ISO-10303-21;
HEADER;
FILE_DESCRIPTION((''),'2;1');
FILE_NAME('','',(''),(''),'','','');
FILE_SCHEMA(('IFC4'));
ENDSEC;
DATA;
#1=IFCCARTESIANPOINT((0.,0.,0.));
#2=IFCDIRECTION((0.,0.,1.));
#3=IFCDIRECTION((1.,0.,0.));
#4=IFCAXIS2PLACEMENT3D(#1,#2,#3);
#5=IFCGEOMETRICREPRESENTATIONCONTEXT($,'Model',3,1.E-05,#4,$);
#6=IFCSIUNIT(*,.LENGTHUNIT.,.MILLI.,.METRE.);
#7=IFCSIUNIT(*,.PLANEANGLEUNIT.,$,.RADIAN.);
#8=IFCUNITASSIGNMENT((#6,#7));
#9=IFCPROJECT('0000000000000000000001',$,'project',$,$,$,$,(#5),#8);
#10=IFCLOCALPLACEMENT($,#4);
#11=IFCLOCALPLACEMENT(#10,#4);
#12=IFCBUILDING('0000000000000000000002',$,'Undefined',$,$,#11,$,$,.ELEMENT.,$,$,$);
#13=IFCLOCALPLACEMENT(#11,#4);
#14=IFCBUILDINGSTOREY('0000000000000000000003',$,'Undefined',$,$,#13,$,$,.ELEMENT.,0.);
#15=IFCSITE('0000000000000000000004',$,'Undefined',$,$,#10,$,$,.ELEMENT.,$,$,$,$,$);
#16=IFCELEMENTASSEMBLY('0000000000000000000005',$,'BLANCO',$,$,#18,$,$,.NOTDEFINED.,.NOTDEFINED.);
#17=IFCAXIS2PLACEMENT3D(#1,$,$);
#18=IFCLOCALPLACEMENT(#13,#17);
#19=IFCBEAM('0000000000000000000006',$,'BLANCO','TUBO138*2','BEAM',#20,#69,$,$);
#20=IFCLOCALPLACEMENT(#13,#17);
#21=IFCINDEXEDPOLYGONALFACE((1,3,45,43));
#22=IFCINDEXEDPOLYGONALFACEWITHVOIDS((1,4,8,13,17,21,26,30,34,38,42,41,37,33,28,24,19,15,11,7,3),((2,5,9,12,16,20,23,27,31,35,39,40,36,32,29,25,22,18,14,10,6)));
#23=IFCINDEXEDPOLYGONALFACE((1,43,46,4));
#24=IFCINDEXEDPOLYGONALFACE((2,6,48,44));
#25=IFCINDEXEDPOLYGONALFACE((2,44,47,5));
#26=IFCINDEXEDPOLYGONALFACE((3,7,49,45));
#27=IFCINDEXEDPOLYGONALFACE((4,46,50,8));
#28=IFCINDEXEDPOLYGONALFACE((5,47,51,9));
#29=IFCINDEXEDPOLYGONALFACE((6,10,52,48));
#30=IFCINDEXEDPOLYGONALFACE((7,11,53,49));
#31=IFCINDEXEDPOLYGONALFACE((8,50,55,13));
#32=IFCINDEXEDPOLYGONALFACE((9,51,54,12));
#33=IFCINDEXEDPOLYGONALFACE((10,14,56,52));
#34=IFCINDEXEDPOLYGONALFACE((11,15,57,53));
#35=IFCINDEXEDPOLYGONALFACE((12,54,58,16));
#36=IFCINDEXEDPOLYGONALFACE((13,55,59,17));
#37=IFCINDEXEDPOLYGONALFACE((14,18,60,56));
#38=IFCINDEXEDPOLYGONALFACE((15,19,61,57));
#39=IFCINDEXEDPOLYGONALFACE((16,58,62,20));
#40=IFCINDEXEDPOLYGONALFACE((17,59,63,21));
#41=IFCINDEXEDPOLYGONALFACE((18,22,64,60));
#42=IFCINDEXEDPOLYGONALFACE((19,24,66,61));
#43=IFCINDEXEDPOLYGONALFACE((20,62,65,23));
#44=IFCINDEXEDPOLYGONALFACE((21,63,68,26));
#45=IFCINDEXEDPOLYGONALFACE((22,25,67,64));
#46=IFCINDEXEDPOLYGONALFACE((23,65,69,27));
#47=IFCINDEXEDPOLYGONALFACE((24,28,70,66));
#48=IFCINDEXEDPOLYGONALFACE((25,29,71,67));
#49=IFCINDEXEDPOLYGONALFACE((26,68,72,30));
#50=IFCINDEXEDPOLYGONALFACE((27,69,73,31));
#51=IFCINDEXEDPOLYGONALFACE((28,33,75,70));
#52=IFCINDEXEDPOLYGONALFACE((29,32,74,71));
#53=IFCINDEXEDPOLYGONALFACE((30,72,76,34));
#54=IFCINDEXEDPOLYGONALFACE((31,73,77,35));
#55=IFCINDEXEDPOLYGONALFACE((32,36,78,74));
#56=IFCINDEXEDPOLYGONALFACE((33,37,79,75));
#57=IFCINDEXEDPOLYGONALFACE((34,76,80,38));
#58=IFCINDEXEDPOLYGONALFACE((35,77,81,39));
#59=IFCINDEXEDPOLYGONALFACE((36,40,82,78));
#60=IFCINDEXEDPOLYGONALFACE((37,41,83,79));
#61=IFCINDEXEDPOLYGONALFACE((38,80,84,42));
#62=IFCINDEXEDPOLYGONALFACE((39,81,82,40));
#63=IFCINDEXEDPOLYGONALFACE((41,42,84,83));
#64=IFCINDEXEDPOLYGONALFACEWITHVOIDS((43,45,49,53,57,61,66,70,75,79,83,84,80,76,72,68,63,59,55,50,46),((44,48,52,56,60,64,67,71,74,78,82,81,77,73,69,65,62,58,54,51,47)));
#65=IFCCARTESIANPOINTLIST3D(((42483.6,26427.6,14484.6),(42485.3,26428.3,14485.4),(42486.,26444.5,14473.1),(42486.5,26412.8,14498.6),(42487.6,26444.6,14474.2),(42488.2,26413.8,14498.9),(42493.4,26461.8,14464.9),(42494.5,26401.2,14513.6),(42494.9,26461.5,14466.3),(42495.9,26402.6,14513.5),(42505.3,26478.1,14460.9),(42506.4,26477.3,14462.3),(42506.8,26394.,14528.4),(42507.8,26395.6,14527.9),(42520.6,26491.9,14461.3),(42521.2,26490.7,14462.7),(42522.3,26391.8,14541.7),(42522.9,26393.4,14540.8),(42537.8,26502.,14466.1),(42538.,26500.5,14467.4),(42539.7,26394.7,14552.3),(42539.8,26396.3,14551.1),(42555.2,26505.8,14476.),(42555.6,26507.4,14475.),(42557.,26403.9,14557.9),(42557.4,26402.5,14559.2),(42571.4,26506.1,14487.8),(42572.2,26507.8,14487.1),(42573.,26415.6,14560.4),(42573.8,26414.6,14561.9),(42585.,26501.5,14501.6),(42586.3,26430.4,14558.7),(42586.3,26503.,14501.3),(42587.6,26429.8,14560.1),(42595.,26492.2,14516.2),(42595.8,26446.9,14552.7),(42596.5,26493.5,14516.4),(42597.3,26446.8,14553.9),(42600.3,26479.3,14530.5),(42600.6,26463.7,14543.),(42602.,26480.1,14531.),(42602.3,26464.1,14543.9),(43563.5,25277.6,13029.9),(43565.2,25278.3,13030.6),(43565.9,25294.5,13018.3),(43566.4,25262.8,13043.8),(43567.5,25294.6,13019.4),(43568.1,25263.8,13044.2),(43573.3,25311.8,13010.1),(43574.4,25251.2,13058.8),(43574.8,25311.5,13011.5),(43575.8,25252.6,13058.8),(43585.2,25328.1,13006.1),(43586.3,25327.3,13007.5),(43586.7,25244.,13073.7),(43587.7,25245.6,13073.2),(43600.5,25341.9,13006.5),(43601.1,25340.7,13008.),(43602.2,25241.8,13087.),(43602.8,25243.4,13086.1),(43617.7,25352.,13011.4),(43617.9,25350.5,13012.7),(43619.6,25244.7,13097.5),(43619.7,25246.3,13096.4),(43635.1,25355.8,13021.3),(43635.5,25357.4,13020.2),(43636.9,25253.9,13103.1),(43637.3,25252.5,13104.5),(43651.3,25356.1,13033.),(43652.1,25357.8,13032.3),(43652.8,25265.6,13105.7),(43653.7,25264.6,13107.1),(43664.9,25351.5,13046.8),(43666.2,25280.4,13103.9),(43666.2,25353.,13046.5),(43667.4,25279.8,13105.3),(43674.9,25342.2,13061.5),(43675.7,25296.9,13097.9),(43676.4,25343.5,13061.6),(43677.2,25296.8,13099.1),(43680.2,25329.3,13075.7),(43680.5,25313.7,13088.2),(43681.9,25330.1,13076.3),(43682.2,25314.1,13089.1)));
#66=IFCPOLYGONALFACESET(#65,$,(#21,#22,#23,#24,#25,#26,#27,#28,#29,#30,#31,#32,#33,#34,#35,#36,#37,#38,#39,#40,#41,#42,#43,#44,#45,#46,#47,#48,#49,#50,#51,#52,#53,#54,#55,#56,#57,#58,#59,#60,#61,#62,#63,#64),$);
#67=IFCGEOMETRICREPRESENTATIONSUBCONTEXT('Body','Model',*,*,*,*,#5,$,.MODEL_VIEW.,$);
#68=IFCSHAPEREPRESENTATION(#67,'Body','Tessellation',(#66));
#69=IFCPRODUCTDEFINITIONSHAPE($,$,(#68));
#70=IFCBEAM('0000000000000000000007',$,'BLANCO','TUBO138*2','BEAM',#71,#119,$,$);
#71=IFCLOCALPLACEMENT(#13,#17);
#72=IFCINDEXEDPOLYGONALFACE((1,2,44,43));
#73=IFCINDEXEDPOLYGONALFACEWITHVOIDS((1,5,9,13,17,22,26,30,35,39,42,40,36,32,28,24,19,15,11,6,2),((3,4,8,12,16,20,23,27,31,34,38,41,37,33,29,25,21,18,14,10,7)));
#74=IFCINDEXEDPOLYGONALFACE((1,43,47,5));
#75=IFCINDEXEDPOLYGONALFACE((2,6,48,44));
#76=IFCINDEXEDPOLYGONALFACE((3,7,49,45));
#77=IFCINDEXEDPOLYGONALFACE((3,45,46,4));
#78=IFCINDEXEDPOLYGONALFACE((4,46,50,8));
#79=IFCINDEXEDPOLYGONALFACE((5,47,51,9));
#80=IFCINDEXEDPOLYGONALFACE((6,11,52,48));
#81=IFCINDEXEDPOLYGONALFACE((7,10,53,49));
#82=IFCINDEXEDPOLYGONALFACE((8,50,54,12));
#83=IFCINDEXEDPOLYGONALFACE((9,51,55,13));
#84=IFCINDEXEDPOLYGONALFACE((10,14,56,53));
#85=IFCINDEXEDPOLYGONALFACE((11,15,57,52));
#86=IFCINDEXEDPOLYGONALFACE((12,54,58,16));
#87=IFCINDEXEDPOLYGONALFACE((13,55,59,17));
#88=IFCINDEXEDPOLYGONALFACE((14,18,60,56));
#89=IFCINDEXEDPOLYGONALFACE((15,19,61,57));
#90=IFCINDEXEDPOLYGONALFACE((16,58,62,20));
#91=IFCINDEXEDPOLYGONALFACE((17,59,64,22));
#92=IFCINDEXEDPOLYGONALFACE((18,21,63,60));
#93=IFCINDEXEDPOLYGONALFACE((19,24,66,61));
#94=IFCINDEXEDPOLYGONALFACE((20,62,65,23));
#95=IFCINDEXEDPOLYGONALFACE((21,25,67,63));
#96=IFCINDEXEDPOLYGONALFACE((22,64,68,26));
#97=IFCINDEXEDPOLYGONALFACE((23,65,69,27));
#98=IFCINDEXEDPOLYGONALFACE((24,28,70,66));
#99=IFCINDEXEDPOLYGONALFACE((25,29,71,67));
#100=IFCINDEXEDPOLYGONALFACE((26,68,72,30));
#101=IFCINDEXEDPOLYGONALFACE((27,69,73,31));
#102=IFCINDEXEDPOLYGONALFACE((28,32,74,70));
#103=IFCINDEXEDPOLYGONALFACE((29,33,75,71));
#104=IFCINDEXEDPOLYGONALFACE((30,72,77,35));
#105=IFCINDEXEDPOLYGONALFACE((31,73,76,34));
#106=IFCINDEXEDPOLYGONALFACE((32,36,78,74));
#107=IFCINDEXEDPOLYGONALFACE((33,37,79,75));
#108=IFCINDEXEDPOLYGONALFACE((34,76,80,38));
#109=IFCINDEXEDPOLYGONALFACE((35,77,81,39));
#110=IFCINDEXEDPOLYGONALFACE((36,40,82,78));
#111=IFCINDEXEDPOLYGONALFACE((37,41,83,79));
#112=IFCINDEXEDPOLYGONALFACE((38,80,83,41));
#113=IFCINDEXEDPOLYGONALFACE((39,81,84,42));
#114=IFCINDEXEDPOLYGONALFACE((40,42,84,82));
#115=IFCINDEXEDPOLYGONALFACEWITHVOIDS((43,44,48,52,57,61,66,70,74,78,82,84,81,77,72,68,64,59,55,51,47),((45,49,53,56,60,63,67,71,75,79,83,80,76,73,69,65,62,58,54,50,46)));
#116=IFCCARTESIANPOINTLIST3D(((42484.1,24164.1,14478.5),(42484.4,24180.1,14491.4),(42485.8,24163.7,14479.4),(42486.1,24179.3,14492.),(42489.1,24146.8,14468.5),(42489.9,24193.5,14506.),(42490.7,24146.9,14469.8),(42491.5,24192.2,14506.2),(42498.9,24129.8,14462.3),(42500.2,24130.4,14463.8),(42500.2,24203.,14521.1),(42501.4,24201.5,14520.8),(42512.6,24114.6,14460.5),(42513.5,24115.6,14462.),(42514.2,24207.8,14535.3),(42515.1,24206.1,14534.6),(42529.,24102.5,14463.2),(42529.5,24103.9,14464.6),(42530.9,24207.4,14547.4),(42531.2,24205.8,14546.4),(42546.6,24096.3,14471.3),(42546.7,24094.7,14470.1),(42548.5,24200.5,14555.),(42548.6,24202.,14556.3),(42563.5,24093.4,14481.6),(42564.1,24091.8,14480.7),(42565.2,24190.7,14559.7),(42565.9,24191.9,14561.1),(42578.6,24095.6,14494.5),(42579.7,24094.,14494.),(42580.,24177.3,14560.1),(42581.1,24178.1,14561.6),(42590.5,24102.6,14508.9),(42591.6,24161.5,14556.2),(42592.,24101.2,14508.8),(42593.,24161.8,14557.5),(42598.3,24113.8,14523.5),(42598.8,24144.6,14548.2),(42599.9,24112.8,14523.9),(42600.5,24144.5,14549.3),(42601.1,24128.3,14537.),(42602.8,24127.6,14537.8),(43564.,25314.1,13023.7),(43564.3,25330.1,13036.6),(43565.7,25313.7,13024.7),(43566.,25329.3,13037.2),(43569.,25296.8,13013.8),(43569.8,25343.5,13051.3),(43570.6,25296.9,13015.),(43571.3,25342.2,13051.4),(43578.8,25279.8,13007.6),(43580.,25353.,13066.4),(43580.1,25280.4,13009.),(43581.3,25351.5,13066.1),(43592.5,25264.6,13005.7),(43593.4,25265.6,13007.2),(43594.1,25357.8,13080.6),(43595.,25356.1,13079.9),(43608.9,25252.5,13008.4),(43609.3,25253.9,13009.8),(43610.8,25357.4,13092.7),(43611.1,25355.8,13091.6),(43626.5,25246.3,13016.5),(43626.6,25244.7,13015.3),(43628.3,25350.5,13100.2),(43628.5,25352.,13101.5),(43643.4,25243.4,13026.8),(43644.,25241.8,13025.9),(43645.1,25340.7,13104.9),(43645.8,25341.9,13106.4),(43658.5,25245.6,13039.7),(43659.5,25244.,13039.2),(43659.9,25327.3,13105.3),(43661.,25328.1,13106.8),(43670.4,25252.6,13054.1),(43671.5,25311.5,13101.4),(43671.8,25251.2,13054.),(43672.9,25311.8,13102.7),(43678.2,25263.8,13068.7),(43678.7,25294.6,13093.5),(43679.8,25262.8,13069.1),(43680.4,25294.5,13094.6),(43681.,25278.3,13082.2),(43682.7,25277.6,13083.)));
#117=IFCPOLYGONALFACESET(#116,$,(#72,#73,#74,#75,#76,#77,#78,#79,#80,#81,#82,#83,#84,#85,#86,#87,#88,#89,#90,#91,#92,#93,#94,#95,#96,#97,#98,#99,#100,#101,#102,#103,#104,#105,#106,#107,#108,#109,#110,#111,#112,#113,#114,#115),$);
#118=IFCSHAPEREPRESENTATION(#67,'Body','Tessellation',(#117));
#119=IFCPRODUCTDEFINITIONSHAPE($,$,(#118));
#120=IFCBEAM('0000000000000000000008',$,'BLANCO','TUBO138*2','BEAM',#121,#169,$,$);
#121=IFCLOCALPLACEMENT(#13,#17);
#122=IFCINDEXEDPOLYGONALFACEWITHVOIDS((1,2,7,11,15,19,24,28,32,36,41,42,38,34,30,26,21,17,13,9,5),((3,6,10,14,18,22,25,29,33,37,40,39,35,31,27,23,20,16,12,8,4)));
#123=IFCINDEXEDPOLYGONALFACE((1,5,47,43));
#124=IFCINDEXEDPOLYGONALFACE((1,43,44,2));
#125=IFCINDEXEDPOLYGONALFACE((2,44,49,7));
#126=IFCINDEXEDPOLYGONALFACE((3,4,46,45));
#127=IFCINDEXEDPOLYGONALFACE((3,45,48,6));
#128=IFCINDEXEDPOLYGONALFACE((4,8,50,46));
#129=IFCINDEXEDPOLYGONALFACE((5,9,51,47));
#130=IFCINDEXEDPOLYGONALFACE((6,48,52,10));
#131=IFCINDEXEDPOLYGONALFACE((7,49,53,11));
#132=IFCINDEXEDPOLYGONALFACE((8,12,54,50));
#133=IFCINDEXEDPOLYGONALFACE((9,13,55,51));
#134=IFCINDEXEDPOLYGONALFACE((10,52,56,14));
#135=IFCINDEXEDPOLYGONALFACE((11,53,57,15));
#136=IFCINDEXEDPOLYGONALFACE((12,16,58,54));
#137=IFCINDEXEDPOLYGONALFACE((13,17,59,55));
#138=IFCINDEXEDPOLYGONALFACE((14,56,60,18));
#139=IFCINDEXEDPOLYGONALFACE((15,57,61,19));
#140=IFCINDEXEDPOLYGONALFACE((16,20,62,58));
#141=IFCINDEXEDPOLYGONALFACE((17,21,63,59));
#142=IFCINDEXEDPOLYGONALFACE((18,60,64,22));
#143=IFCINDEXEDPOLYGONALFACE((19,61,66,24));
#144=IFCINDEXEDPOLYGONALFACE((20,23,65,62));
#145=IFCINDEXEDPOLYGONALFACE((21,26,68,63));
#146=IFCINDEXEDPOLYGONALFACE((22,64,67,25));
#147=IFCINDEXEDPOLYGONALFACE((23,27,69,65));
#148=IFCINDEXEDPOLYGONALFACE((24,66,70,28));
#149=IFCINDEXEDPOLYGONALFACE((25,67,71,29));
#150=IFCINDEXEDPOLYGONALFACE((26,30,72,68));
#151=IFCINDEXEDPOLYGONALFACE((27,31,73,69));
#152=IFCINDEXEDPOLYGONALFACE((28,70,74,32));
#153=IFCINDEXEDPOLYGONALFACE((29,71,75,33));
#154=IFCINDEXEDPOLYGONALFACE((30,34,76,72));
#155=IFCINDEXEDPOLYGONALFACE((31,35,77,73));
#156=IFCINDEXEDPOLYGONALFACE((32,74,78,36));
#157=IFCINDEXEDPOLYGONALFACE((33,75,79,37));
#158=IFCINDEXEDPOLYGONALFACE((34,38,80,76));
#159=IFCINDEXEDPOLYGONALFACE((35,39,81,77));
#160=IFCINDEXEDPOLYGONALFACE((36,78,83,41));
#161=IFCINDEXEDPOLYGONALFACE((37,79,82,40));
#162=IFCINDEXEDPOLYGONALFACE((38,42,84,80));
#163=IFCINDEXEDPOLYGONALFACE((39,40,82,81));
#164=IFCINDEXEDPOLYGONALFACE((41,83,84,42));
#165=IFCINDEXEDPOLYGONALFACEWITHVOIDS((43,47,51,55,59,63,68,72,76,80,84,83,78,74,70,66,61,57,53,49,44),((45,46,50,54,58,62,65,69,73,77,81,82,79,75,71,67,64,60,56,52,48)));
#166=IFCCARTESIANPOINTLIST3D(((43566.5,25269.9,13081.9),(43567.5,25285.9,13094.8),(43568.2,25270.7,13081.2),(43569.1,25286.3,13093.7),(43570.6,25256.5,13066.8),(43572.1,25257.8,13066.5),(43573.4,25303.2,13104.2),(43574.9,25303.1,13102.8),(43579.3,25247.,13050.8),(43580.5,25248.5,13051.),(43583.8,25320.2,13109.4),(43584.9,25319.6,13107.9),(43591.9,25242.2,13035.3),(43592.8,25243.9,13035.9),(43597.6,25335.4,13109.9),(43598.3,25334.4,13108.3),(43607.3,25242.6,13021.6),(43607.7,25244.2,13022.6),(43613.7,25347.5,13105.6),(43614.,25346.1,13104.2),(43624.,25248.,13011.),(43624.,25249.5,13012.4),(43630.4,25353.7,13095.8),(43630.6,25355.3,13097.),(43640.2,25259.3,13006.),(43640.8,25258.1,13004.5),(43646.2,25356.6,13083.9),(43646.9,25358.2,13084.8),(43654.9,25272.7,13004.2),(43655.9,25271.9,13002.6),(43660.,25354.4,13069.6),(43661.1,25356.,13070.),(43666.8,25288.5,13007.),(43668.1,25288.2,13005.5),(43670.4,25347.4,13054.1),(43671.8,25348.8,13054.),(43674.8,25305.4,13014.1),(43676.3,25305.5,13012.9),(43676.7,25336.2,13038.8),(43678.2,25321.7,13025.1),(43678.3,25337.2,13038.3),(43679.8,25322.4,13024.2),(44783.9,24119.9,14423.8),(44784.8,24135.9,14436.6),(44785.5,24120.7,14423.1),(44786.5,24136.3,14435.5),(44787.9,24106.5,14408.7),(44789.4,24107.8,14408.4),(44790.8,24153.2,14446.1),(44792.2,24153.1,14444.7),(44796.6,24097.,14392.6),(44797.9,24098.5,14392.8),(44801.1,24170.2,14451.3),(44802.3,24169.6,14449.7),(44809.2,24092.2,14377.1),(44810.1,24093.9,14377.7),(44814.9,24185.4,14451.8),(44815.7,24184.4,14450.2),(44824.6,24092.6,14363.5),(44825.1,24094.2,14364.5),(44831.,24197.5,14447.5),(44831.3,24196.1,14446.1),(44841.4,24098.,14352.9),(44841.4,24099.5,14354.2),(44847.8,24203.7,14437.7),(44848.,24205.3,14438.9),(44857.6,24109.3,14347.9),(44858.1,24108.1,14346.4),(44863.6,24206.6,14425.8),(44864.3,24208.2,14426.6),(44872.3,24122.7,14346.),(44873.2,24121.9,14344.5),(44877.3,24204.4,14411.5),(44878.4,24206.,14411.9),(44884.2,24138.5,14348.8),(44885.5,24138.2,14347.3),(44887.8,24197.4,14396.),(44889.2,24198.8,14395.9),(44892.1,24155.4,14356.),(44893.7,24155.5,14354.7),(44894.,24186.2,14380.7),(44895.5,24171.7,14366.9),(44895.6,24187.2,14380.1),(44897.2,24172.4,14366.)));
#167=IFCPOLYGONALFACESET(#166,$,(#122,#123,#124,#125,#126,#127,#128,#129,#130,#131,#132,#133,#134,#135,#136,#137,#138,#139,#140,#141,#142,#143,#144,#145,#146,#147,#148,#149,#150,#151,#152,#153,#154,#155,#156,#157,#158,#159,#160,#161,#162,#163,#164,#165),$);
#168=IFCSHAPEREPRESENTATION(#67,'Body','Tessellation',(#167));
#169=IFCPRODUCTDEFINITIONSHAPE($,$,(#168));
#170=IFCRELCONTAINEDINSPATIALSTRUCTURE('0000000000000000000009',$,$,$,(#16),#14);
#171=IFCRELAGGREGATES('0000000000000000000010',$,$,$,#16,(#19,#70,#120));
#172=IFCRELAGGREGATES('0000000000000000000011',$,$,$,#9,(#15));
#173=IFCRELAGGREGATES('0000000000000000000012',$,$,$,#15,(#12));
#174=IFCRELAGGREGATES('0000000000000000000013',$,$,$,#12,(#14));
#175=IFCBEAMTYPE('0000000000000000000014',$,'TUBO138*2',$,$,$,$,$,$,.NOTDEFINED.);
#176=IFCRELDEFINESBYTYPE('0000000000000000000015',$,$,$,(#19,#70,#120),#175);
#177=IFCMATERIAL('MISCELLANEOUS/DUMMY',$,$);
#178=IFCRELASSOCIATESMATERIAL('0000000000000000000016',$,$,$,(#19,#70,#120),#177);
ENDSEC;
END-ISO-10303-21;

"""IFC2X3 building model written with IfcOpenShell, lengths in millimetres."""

from ifc_helpers import new_model, si_unit, frame, origin_with_axes, origin_2d_with_axis, place, context, subcontext, project, spatial, hollow_circle, extrude, material, type_object, element, aggregate, save


model = new_model("IFC2X3")

# Units and contexts
model_context = context("Model", 3, precision=1e-05, world=origin_with_axes())
body_context = subcontext(model_context, "Body", "Model", "MODEL_VIEW")
ifc_project = project(units=[si_unit("LENGTHUNIT", "METRE", prefix="MILLI"), si_unit("PLANEANGLEUNIT", "RADIAN")], contexts=[model_context])

# Site, building, storey
site_placement = place(None, origin_with_axes())
site = spatial("IfcSite", under=ifc_project, at=site_placement, Name="Undefined", CompositionType="ELEMENT")
building_placement = place(site_placement, origin_with_axes())
building = spatial("IfcBuilding", under=site, at=building_placement, Name="Undefined", CompositionType="ELEMENT")
storey_placement = place(building_placement, origin_with_axes())
storey = spatial("IfcBuildingStorey", under=building, at=storey_placement, Name="Undefined", CompositionType="ELEMENT", Elevation=0.0)

# Element assembly, beams
assembly_placement = place(storey_placement, origin_with_axes())
assembly = element("IfcElementAssembly", 1, at=assembly_placement, inside=storey, Name="BLANCO", AssemblyPlace="NOTDEFINED", PredefinedType="NOTDEFINED")
ifc_material = material(Name="MISCELLANEOUS/DUMMY")
beam_type = type_object("IfcBeamType", Name="TUBO138*2", PredefinedType="NOTDEFINED")
beam_1_placement = place(assembly_placement, frame((43623.1, 25300.0, 13056.4), z_axis=(-0.497966, 0.461316, -0.734314), x_axis=(-0.503224, 0.535899, 0.677922)))
beam_1 = element("IfcBeam", 2, at=beam_1_placement, type_object=beam_type, material=ifc_material, Name="BLANCO", Description="TUBO138*2", ObjectType="BEAM", context=body_context, shape_type="SweptSolid", body=[
    extrude(hollow_circle(Radius=69.0, WallThickness=2.0, at=origin_2d_with_axis()), frame((2145.9, 0.0, 0.0), z_axis=(-1.0, 0.0, 0.0), x_axis=(0.0, -1.0, 0.0)), (0.0, 0.0, 1.0), 2145.9),
])
beam_2_placement = place(assembly_placement, frame((43623.1, 25300.0, 13056.4), z_axis=(-0.497966, -0.461316, -0.734314), x_axis=(-0.503224, -0.535899, 0.677922)))
beam_2 = element("IfcBeam", 3, at=beam_2_placement, type_object=beam_type, material=ifc_material, Name="BLANCO", Description="TUBO138*2", ObjectType="BEAM", context=body_context, shape_type="SweptSolid", body=[
    extrude(hollow_circle(Radius=69.0, WallThickness=2.0, at=origin_2d_with_axis()), frame((2145.9, 0.0, 0.0), z_axis=(-1.0, 0.0, 0.0), x_axis=(0.0, -1.0, 0.0)), (0.0, 0.0, 1.0), 2145.9),
])
beam_3_placement = place(assembly_placement, frame((43623.1, 25300.0, 13056.4), z_axis=(0.423552, -0.461316, -0.77961), x_axis=(0.567282, -0.535899, 0.625303)))
beam_3 = element("IfcBeam", 4, at=beam_3_placement, type_object=beam_type, material=ifc_material, Name="BLANCO", Description="TUBO138*2", ObjectType="BEAM", context=body_context, shape_type="SweptSolid", body=[
    extrude(hollow_circle(Radius=69.0, WallThickness=2.0, at=origin_2d_with_axis()), frame((2145.9, 0.0, 0.0), z_axis=(-1.0, 0.0, 0.0), x_axis=(0.0, -1.0, 0.0)), (0.0, 0.0, 1.0), 2145.9),
])
aggregate(assembly, [beam_1, beam_2, beam_3])

save(model, "model.ifc")
